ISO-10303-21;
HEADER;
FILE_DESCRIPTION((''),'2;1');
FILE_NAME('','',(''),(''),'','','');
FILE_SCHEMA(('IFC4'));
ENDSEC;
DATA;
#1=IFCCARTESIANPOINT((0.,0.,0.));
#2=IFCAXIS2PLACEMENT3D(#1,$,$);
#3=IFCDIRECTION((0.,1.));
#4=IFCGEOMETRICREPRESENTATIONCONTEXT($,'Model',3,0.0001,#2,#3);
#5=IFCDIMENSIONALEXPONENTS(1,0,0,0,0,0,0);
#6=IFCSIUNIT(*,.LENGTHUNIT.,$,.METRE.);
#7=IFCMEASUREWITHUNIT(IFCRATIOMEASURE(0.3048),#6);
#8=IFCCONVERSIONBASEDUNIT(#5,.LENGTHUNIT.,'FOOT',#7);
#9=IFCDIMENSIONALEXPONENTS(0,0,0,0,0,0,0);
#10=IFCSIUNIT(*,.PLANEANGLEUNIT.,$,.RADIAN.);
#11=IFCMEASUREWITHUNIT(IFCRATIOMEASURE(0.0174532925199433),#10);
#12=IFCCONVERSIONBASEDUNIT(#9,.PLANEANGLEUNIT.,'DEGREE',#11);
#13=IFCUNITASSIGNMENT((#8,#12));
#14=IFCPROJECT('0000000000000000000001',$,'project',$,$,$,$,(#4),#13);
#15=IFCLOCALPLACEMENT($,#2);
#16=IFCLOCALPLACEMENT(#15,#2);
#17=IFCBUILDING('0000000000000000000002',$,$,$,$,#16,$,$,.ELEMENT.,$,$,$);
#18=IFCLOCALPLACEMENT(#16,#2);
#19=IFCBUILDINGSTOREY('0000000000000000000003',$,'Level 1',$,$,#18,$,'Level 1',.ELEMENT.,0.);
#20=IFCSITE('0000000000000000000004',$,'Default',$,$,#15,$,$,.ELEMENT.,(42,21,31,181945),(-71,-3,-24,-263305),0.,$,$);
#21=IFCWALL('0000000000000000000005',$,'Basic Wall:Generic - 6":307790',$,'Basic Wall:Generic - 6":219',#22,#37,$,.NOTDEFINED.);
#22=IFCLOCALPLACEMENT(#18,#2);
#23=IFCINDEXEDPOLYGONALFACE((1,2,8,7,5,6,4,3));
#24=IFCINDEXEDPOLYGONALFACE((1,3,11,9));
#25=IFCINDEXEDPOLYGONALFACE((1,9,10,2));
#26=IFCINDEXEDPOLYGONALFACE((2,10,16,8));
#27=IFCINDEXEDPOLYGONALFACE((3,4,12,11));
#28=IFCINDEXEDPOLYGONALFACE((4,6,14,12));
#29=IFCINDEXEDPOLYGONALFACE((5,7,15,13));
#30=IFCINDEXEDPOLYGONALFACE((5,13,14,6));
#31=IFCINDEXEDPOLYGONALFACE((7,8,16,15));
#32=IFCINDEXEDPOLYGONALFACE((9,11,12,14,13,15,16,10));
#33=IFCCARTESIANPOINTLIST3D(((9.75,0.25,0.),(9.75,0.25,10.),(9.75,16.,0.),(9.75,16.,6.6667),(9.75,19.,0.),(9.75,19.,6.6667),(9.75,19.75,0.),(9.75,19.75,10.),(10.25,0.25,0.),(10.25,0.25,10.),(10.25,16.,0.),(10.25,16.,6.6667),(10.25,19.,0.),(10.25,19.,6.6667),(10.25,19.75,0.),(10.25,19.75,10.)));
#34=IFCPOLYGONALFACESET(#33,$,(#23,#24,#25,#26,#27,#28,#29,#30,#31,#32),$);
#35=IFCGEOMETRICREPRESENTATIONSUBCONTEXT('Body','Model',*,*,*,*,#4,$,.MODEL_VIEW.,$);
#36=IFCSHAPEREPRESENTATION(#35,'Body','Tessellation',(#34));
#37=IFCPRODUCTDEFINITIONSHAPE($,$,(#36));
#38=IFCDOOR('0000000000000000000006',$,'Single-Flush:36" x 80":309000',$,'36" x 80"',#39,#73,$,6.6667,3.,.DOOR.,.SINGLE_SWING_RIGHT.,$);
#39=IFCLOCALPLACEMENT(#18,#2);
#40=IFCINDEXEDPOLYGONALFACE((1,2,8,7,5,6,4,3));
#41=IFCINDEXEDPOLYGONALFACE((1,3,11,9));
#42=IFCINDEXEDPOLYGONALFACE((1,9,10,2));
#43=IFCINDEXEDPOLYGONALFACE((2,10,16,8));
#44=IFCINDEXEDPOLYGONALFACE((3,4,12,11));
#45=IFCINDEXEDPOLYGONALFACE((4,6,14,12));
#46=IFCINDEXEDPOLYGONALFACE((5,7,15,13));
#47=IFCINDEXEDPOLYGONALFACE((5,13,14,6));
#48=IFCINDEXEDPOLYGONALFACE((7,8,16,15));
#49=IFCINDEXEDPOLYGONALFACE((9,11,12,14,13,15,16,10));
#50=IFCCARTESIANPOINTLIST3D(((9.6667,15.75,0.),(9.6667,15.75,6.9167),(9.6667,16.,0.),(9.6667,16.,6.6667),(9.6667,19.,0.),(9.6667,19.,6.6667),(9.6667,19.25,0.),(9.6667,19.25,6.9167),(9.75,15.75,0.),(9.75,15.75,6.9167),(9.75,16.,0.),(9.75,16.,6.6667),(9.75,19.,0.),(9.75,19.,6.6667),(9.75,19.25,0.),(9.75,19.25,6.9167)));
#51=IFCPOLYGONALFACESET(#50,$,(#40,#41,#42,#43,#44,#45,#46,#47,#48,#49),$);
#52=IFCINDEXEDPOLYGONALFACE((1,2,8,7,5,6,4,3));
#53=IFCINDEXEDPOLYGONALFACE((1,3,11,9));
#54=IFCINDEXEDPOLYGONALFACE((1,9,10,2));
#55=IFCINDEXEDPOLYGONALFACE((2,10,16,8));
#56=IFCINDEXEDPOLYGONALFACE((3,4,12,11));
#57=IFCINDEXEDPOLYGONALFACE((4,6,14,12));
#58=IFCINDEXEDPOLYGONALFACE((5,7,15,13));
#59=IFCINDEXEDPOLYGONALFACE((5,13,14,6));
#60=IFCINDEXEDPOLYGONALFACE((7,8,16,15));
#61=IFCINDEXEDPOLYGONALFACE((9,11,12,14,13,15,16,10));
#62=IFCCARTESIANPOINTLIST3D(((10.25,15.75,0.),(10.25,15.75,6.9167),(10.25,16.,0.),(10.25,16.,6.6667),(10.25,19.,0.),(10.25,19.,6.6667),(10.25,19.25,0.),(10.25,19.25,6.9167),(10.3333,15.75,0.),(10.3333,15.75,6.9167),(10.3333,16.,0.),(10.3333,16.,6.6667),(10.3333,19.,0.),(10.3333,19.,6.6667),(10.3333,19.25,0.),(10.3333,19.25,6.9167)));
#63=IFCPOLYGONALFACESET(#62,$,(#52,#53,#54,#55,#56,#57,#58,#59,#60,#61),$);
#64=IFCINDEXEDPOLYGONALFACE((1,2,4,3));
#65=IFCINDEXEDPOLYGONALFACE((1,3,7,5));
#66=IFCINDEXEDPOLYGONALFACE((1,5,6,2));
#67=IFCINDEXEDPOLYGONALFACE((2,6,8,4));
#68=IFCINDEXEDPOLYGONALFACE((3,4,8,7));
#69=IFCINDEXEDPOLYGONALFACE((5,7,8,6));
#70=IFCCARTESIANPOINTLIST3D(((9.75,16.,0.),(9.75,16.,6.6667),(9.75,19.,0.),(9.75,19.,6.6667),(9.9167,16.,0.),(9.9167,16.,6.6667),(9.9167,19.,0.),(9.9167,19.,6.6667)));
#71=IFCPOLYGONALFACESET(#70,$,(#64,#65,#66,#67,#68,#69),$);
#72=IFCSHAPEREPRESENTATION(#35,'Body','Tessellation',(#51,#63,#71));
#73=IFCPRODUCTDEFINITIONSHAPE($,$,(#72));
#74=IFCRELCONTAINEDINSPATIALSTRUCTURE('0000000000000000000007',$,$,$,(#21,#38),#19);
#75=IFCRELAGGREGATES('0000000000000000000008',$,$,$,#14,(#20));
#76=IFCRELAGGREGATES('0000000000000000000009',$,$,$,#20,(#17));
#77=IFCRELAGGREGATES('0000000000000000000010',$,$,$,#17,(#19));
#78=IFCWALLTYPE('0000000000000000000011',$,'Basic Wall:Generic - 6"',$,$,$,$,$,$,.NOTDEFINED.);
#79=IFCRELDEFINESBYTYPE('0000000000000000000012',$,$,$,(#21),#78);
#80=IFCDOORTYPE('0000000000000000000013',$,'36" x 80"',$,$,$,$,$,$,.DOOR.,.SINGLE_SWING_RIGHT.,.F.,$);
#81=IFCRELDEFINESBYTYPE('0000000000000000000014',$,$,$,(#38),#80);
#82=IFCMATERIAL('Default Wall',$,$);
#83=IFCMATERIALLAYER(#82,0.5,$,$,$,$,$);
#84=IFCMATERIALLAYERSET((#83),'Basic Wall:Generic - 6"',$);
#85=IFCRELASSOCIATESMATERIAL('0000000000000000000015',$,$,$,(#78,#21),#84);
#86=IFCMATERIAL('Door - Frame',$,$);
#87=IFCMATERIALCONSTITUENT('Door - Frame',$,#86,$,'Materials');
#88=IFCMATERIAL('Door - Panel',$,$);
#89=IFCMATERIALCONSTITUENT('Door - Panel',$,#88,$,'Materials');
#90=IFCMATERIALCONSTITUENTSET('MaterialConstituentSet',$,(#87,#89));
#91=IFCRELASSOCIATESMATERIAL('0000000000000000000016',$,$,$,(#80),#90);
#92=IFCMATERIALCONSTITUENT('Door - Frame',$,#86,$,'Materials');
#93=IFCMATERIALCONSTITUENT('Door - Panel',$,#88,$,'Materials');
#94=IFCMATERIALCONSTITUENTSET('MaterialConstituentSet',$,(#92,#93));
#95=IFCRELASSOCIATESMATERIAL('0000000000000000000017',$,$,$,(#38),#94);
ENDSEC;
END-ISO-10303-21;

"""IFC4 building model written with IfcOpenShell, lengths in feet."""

from ifc_helpers import new_model, entity, si_unit, converted_unit, direction, frame, frame_2d, origin, origin_2d_with_axis, place, context, subcontext, project, spatial, polyline, rectangle, outline, extrude, source, transform, mapped, material, layer, layer_set, layer_usage, constituent, constituent_set, type_object, type_shapes, element, fill, save


model = new_model("IFC4")

# Units and contexts
model_context = context("Model", 3, precision=0.0001, world=origin(), true_north=direction((0.0, 1.0)))
body_context = subcontext(model_context, "Body", "Model", "MODEL_VIEW")
ifc_project = project(units=[converted_unit("LENGTHUNIT", "FOOT", entity("IfcRatioMeasure", 0.3048), si_unit("LENGTHUNIT", "METRE"), dimensions=[1, 0, 0, 0, 0, 0, 0]), converted_unit("PLANEANGLEUNIT", "DEGREE", entity("IfcRatioMeasure", 0.0174532925199433), si_unit("PLANEANGLEUNIT", "RADIAN"), dimensions=[0, 0, 0, 0, 0, 0, 0])], contexts=[model_context])

# Site, building, storey
site_placement = place(None, origin())
site = spatial("IfcSite", under=ifc_project, at=site_placement, Name="Default", CompositionType="ELEMENT", RefLatitude=(42, 21, 31, 181945), RefLongitude=(-71, -3, -24, -263305), RefElevation=0.0)
building_placement = place(site_placement, origin())
building = spatial("IfcBuilding", under=site, at=building_placement, CompositionType="ELEMENT")
storey_placement = place(building_placement, origin())
storey = spatial("IfcBuildingStorey", under=building, at=storey_placement, Name="Level 1", LongName="Level 1", CompositionType="ELEMENT", Elevation=0.0)

# Shared definitions
wall_1_placement = place(storey_placement, frame((10.0, 19.75, 0.0), z_axis=(0.0, 0.0, 1.0), x_axis=(0.0, -1.0, 0.0)))

# Wall, opening, door
ifc_material_1 = material(Name="Default Wall")
ifc_layer = layer(ifc_material_1, 0.5)
ifc_layer_set = layer_set([ifc_layer], Name="Basic Wall:Generic - 6\"")
wall_type = type_object("IfcWallType", Name="Basic Wall:Generic - 6\"", PredefinedType="NOTDEFINED", material=ifc_layer_set)
ifc_material_2 = material(Name="Door - Frame")
ifc_material_3 = material(Name="Door - Panel")
ifc_constituent_1 = constituent(ifc_material_2, Name="Door - Frame", Category="Materials")
ifc_constituent_2 = constituent(ifc_material_3, Name="Door - Panel", Category="Materials")
ifc_constituent_set_1 = constituent_set(constituents=[ifc_constituent_1, ifc_constituent_2], Name="MaterialConstituentSet")
door_type = type_object("IfcDoorType", Name="36\" x 80\"", OperationType="SINGLE_SWING_RIGHT", ParameterTakesPrecedence=False, PredefinedType="DOOR", material=ifc_constituent_set_1)
shared_shape = source(origin(), body_context, "Body", "SweptSolid", [
    extrude(outline(polyline([(-1.75, -3.5208), (1.75, -3.5208), (1.75, 3.3958), (1.5, 3.3958), (1.5, -3.2708), (-1.5, -3.2708), (-1.5, 3.3958), (-1.75, 3.3958), (-1.75, -3.5208)])), frame((1.5, 0.5, 3.3958), z_axis=(0.0, 1.0, 0.0), x_axis=(1.0, 0.0, 0.0)), (0.0, 0.0, 1.0), 0.0833),
    extrude(outline(polyline([(-3.5208, -1.75), (3.3958, -1.75), (3.3958, -1.5), (-3.2708, -1.5), (-3.2708, 1.5), (3.3958, 1.5), (3.3958, 1.75), (-3.5208, 1.75), (-3.5208, -1.75)])), frame((1.5, -0.0833, 3.3958), z_axis=(0.0, 1.0, 0.0), x_axis=(0.0, 0.0, -1.0)), (0.0, 0.0, 1.0), 0.0833),
    extrude(rectangle(XDim=0.1667, YDim=3.0, at=origin_2d_with_axis()), frame((1.5, 0.4167, 0.0), z_axis=(0.0, 0.0, 1.0), x_axis=(0.0, 1.0, 0.0)), (0.0, 0.0, 1.0), 6.6667),
])
type_shapes(door_type, [shared_shape])
ifc_layer_usage_1 = layer_usage(ifc_layer_set, "AXIS2", "NEGATIVE", 0.25)
wall_1 = element("IfcWall", 1, at=wall_1_placement, inside=storey, type_object=wall_type, material=ifc_layer_usage_1, Name="Basic Wall:Generic - 6\":307790", ObjectType="Basic Wall:Generic - 6\":219", PredefinedType="NOTDEFINED", context=body_context, shape_type="SweptSolid", body=[
    extrude(rectangle(XDim=19.5, YDim=0.5, at=frame_2d((9.75, 0.0), x_axis=(-1.0, 0.0))), origin(), (0.0, 0.0, 1.0), 10.0),
])
opening_1_placement = place(wall_1_placement, frame((3.75, 0.25, 0.0)))
opening_1 = element("IfcOpeningElement", 2, at=opening_1_placement, cuts=wall_1, ObjectType="Opening", PredefinedType="OPENING", context=body_context, shape_type="SweptSolid", body=[
    extrude(rectangle(XDim=3.0, YDim=6.6667, at=frame_2d((3.3333, 1.5), x_axis=(0.0, 1.0))), frame((0.0, 0.0, 0.0), z_axis=(0.0, -1.0, 0.0), x_axis=(0.0, 0.0, 1.0)), (0.0, 0.0, 1.0), 0.5),
])
ifc_constituent_3 = constituent(ifc_material_2, Name="Door - Frame", Category="Materials")
ifc_constituent_4 = constituent(ifc_material_3, Name="Door - Panel", Category="Materials")
ifc_constituent_set_2 = constituent_set(constituents=[ifc_constituent_3, ifc_constituent_4], Name="MaterialConstituentSet")
door_1_placement = place(opening_1_placement, frame((0.0, 0.0, 0.0), z_axis=(0.0, 0.0, 1.0), x_axis=(-1.0, 0.0, 0.0)))
door_1 = element("IfcDoor", 3, at=door_1_placement, inside=storey, type_object=door_type, material=ifc_constituent_set_2, Name="Single-Flush:36\" x 80\":309000", ObjectType="36\" x 80\"", OperationType="SINGLE_SWING_RIGHT", OverallHeight=6.6667, OverallWidth=3.0, PredefinedType="DOOR", context=body_context, shape_type="MappedRepresentation", body=[
    mapped(shared_shape, transform((0.0, 0.0, 0.0), scale=1.0)),
])
fill(opening_1, door_1)

save(model, "model.ifc")
